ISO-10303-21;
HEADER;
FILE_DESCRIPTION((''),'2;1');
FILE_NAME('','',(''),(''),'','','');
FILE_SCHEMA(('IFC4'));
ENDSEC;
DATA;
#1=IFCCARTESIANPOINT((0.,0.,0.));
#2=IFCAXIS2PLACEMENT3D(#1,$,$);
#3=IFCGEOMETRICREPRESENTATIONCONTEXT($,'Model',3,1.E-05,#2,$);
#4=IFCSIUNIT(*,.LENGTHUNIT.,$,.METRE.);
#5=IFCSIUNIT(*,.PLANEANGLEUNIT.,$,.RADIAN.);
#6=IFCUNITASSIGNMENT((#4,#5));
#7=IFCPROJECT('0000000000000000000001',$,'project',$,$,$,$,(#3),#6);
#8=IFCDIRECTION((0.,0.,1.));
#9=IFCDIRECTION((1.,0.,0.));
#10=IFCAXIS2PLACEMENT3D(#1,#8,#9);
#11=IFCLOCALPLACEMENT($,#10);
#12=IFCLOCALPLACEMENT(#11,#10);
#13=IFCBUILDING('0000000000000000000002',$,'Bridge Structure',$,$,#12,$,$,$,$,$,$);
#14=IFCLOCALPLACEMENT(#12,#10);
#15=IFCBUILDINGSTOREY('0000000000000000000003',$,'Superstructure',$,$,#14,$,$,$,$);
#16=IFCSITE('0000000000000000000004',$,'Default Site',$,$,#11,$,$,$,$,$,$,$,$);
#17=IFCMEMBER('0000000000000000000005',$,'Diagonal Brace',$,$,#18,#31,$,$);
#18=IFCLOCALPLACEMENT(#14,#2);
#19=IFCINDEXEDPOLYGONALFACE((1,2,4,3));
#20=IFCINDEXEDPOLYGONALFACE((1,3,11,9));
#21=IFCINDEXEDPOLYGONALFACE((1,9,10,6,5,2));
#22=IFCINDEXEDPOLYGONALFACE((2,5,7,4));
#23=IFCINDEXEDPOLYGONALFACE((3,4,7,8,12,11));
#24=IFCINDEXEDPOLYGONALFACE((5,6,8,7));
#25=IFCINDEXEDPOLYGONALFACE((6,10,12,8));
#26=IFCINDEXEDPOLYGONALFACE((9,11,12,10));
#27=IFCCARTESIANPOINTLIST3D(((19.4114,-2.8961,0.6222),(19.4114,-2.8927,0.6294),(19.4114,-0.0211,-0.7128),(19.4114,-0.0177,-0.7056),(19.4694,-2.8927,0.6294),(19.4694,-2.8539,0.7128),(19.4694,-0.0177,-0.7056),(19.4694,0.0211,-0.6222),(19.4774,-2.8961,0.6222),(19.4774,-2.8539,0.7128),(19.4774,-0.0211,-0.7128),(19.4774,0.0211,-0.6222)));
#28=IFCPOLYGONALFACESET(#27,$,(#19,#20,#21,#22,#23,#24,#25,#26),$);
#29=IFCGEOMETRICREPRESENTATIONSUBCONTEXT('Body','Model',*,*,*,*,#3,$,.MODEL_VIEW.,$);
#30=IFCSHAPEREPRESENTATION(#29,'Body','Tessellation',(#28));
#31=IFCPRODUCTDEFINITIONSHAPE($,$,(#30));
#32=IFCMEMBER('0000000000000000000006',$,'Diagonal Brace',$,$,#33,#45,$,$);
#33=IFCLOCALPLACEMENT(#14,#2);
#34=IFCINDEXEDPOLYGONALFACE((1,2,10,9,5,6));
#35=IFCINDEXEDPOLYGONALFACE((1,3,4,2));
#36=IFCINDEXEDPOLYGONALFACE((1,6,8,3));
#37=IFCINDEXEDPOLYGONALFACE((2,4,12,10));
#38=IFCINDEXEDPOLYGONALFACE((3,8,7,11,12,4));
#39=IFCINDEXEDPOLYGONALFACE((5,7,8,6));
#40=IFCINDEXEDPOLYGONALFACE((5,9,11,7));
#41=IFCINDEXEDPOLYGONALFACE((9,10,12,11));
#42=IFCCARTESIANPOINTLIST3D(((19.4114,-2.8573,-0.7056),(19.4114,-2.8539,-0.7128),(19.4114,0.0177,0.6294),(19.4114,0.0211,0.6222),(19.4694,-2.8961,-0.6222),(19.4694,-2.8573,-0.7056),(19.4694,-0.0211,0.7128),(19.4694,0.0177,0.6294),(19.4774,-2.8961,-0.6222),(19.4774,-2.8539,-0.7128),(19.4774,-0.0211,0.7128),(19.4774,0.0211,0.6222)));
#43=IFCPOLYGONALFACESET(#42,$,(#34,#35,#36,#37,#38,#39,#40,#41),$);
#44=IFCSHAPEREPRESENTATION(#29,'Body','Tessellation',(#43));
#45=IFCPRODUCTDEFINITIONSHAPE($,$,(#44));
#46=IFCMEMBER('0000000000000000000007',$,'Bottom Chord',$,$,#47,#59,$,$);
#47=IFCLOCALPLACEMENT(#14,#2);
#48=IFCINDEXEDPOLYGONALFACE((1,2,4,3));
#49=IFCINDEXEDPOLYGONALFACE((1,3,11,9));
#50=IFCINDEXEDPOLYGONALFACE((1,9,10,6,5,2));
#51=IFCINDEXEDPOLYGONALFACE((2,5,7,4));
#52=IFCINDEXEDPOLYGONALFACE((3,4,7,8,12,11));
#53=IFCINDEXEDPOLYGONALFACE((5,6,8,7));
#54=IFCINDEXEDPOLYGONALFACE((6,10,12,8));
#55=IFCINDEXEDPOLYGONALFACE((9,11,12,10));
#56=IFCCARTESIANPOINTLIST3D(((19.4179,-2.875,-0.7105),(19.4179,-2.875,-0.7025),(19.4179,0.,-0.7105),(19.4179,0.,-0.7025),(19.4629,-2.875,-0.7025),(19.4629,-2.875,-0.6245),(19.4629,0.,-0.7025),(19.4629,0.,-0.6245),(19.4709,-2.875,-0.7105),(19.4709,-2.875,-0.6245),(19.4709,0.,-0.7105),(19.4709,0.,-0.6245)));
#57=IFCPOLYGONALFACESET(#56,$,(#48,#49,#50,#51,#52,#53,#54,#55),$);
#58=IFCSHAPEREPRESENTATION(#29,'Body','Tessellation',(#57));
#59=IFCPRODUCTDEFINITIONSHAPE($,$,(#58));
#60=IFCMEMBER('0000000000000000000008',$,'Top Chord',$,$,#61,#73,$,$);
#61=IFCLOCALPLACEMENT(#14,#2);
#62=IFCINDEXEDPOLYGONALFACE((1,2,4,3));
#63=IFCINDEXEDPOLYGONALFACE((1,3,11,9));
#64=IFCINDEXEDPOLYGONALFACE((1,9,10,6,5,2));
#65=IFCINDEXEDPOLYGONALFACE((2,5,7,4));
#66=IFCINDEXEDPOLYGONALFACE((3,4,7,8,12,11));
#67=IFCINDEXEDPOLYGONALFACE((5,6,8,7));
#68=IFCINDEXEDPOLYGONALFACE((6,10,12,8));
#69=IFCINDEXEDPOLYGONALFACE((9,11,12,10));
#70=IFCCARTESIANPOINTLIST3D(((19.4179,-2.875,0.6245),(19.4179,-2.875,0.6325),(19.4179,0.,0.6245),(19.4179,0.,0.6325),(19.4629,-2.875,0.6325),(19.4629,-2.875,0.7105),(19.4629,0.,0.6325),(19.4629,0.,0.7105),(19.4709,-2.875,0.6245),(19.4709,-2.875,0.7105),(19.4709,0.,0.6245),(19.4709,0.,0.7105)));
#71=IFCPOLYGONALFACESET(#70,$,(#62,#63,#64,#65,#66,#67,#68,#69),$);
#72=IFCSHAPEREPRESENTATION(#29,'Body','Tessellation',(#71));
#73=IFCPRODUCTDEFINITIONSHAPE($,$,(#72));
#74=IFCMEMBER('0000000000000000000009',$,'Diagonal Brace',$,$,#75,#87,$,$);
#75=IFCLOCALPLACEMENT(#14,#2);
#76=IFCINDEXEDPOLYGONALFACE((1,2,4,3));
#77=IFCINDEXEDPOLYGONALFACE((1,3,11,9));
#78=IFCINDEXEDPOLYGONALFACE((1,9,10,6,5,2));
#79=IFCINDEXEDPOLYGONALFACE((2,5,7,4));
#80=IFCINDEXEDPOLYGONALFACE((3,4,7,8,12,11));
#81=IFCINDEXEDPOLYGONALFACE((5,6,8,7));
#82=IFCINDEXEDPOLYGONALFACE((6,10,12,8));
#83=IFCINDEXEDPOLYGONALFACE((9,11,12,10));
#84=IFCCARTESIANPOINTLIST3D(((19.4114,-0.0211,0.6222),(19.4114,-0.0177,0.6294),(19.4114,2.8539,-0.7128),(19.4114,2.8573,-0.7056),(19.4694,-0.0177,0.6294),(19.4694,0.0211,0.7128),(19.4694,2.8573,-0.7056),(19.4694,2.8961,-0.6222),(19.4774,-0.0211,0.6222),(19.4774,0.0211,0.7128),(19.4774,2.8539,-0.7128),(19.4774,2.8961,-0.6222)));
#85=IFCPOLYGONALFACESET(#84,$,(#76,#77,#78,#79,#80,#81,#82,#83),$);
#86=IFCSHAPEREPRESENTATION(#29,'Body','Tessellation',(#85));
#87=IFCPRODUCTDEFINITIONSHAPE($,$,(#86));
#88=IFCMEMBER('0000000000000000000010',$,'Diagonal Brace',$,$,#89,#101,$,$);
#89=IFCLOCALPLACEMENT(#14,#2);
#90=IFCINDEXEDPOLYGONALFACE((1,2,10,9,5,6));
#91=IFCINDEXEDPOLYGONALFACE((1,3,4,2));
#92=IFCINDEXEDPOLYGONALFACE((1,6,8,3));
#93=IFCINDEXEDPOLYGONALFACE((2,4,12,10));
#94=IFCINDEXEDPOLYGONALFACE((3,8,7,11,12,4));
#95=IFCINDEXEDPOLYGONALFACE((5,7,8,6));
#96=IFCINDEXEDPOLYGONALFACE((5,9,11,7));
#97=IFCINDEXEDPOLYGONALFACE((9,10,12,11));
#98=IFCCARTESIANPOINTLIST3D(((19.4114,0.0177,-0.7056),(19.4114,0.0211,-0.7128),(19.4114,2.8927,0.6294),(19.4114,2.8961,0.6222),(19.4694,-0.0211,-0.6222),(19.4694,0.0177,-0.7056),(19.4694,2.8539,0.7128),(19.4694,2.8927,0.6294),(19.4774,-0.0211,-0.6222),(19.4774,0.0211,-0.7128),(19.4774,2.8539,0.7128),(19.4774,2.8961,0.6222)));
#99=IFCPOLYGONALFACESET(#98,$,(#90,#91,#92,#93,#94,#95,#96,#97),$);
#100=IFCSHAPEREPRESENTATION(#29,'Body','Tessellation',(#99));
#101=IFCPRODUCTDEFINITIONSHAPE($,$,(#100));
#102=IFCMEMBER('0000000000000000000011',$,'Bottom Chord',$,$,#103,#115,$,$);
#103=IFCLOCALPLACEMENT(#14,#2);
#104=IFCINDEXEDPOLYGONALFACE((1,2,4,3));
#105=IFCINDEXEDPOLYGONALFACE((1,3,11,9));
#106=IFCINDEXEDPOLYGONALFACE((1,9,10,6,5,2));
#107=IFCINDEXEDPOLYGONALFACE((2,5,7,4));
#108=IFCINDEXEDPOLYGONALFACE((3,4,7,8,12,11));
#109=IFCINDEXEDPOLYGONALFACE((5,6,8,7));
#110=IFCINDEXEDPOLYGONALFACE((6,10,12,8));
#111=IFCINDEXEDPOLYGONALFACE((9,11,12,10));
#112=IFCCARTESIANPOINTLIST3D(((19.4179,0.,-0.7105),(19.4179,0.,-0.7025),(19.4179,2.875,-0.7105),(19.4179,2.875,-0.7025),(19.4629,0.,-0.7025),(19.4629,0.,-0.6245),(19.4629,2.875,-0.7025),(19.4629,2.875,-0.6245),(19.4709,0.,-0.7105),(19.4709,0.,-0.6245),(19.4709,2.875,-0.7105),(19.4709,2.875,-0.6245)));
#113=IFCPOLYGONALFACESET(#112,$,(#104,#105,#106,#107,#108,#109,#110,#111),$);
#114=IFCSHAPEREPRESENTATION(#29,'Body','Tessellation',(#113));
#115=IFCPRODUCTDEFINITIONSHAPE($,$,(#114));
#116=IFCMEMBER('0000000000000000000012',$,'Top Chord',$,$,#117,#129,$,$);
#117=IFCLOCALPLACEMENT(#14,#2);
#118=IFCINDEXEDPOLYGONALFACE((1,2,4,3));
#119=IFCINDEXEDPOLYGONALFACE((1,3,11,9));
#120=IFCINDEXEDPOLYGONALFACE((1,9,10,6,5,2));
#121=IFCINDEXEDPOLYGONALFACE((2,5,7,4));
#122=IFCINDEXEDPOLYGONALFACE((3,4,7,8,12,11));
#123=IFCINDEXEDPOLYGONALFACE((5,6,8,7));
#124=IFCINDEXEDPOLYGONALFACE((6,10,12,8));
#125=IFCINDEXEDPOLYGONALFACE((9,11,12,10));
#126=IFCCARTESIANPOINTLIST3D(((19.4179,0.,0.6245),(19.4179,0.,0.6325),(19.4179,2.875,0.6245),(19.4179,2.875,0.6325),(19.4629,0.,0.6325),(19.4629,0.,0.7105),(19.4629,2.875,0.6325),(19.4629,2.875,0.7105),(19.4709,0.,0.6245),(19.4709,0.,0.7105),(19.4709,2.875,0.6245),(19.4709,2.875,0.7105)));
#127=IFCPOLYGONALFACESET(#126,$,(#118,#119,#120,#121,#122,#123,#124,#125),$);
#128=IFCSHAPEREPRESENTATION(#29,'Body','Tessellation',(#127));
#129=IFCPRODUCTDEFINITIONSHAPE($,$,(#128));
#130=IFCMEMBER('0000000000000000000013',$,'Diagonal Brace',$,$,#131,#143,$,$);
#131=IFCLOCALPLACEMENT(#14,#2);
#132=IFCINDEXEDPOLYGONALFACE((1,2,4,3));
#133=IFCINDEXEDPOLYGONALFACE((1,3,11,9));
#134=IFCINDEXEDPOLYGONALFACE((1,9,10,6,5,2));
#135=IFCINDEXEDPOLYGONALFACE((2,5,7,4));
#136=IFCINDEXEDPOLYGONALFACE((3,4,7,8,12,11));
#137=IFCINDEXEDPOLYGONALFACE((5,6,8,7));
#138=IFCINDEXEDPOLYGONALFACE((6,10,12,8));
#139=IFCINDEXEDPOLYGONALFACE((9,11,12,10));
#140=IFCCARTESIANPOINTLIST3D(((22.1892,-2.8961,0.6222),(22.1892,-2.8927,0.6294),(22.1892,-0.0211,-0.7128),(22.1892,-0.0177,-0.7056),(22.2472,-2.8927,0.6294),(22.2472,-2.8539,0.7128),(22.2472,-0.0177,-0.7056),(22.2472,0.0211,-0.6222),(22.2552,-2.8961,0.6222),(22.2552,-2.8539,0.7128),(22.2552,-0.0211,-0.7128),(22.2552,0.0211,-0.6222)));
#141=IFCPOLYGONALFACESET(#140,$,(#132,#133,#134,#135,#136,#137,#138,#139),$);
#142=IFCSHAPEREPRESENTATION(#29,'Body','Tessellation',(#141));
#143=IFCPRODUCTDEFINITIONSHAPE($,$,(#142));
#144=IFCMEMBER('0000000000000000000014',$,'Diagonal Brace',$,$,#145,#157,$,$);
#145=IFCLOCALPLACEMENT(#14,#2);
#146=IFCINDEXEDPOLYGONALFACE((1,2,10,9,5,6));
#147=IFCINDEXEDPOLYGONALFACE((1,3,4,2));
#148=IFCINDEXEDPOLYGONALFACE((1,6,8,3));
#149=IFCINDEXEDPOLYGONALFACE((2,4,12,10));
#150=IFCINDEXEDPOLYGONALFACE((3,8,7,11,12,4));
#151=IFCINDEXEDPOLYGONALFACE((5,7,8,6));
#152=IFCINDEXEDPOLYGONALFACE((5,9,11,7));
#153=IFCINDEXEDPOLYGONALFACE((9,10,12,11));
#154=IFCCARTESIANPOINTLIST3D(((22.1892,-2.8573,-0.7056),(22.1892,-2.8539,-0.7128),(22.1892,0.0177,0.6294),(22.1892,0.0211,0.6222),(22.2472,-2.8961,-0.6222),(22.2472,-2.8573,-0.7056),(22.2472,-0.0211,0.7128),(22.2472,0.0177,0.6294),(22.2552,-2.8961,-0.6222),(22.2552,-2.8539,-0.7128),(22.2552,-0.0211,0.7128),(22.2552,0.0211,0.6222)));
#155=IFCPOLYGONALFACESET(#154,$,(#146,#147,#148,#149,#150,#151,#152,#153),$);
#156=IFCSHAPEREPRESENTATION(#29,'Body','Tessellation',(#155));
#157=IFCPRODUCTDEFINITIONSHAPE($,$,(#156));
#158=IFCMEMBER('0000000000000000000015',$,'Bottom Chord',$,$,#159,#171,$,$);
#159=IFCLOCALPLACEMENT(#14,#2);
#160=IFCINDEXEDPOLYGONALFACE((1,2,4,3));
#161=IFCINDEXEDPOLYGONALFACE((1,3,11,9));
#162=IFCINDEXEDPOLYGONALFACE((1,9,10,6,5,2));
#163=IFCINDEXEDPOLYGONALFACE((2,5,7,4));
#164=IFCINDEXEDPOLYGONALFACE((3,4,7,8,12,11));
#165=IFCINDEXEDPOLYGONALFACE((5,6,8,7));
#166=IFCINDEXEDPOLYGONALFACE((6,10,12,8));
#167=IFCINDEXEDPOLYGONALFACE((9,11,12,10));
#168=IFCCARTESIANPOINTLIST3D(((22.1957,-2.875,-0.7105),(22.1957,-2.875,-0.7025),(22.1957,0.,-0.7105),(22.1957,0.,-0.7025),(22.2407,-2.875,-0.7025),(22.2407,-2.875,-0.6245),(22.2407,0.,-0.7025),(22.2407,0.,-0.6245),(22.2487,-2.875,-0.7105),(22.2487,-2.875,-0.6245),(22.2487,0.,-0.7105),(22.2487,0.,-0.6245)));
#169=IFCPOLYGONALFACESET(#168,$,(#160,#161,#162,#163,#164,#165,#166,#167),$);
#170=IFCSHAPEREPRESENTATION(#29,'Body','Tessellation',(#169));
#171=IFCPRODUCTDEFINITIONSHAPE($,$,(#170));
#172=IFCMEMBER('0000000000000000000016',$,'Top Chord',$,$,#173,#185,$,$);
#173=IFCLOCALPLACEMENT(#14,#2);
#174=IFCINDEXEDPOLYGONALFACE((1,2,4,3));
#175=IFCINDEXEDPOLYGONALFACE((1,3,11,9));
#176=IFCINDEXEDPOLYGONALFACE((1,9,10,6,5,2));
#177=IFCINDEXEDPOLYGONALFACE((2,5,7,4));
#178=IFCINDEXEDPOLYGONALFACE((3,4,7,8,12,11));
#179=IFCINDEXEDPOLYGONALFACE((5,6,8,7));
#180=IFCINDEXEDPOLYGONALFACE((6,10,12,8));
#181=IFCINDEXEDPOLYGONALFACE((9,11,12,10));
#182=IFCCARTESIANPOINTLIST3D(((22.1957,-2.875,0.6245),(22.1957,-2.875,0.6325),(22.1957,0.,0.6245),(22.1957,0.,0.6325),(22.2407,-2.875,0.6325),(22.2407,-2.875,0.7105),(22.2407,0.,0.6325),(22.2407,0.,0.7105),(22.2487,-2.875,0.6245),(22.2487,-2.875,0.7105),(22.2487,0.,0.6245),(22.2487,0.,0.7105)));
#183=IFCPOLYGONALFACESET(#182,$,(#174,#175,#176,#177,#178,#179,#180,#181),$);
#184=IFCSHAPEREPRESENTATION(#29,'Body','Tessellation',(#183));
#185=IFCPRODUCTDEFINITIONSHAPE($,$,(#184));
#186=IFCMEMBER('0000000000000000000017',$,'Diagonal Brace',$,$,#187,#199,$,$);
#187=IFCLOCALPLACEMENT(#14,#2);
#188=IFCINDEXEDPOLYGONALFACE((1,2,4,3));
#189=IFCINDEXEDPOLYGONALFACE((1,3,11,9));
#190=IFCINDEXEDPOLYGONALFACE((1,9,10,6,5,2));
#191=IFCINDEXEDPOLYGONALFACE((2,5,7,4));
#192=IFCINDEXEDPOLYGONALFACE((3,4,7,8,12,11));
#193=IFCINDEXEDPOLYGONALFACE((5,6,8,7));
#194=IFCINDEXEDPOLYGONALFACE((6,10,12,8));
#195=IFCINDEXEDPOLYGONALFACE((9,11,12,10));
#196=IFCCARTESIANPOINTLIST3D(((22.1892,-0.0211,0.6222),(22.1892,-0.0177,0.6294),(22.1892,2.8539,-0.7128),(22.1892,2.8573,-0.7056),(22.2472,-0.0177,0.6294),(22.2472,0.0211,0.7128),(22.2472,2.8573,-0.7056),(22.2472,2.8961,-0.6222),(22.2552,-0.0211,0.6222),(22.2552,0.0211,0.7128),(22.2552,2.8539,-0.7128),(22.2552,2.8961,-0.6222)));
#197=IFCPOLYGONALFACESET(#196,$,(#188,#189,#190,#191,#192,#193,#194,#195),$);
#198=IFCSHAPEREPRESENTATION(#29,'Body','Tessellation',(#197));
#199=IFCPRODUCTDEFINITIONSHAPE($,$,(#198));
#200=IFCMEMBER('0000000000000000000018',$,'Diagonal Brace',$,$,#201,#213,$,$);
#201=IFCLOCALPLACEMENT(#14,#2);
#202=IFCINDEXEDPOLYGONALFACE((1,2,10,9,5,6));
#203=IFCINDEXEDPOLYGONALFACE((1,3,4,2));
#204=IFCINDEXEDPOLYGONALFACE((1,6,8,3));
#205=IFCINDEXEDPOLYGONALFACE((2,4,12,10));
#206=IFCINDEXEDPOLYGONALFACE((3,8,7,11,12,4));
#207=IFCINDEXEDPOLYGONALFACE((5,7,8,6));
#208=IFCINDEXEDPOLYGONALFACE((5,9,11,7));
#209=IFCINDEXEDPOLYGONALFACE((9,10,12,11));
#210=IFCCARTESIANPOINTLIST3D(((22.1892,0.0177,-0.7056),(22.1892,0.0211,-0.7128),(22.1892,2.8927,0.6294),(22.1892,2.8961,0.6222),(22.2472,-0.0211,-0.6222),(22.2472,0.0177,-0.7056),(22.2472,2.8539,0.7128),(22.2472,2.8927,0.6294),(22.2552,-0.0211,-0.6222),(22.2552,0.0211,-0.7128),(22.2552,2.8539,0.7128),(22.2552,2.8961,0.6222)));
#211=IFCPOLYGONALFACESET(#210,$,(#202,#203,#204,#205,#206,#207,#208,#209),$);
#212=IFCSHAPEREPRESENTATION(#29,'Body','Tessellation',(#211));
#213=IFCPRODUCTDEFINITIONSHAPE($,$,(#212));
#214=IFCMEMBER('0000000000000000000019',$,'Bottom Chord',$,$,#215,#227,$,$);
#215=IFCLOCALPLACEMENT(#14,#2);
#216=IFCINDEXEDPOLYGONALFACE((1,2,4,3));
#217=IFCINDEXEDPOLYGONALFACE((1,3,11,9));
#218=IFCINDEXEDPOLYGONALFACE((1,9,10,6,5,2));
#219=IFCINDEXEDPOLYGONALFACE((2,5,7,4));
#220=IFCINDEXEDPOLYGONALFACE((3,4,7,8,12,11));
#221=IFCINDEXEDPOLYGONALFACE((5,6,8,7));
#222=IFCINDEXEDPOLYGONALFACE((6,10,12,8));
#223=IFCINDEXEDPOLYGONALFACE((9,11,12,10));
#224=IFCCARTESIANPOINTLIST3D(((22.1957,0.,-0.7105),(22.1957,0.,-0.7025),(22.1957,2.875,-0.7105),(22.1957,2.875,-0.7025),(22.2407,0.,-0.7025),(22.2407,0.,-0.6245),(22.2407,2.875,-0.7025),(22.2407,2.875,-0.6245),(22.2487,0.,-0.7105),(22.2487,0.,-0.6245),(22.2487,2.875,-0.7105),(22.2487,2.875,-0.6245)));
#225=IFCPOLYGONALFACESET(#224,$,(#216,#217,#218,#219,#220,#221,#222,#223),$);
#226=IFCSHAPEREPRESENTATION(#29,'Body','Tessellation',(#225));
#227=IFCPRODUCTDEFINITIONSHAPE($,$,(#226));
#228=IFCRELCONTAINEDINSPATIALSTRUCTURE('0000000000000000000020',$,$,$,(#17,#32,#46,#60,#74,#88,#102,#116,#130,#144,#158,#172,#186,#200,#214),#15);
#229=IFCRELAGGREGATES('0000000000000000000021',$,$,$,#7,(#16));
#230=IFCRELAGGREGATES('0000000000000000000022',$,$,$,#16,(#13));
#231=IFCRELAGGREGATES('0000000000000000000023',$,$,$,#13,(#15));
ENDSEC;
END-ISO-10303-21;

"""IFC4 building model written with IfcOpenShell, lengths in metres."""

from ifc_helpers import new_model, si_unit, frame, origin, origin_with_axes, origin_2d_with_axis, place, context, subcontext, project, spatial, l_section, extrude, element, save


model = new_model("IFC4")

# Units and contexts
model_context = context("Model", 3, precision=1e-05, world=origin())
body_context = subcontext(model_context, "Body", "Model", "MODEL_VIEW")
ifc_project = project(units=[si_unit("LENGTHUNIT", "METRE"), si_unit("PLANEANGLEUNIT", "RADIAN")], contexts=[model_context])

# Site, building, storey
site_placement = place(None, origin_with_axes())
site = spatial("IfcSite", under=ifc_project, at=site_placement, Name="Default Site")
building_placement = place(site_placement, origin_with_axes())
building = spatial("IfcBuilding", under=site, at=building_placement, Name="Bridge Structure")
storey_placement = place(building_placement, origin_with_axes())
storey = spatial("IfcBuildingStorey", under=building, at=storey_placement, Name="Superstructure")

# Members
for number, where, z_axis, x_axis, name in (
    (1, (19.4444, -2.875, 0.6675), (0.0, 0.906987, -0.421158), (-1.0, 0.0, 0.0), "Diagonal Brace"),
    (2, (19.4444, -2.875, -0.6675), (0.0, 0.906987, 0.421158), (-1.0, 0.0, 0.0), "Diagonal Brace"),
):
    element("IfcMember", number, at=place(storey_placement, frame(where, z_axis=z_axis, x_axis=x_axis)), inside=storey, Name=name, context=body_context, shape_type="SweptSolid", body=[
        extrude(l_section(Depth=0.1, Width=0.066, Thickness=0.008, at=origin_2d_with_axis()), origin_with_axes(), (0.0, 0.0, 1.0), 3.1698),
    ])
for number, where, z_axis, x_axis, name in (
    (3, (19.4444, -2.875, -0.6675), (0.0, 1.0, 0.0), (-1.0, 0.0, 0.0), "Bottom Chord"),
    (4, (19.4444, -2.875, 0.6675), (0.0, 1.0, 0.0), (-1.0, 0.0, 0.0), "Top Chord"),
):
    element("IfcMember", number, at=place(storey_placement, frame(where, z_axis=z_axis, x_axis=x_axis)), inside=storey, Name=name, context=body_context, shape_type="SweptSolid", body=[
        extrude(l_section(Depth=0.086, Width=0.053, Thickness=0.008, at=origin_2d_with_axis()), origin_with_axes(), (0.0, 0.0, 1.0), 2.875),
    ])
for number, where, z_axis, x_axis, name in (
    (5, (19.4444, 0.0, 0.6675), (0.0, 0.906987, -0.421158), (-1.0, 0.0, 0.0), "Diagonal Brace"),
    (6, (19.4444, 0.0, -0.6675), (0.0, 0.906987, 0.421158), (-1.0, 0.0, 0.0), "Diagonal Brace"),
):
    element("IfcMember", number, at=place(storey_placement, frame(where, z_axis=z_axis, x_axis=x_axis)), inside=storey, Name=name, context=body_context, shape_type="SweptSolid", body=[
        extrude(l_section(Depth=0.1, Width=0.066, Thickness=0.008, at=origin_2d_with_axis()), origin_with_axes(), (0.0, 0.0, 1.0), 3.1698),
    ])
for number, where, z_axis, x_axis, name in (
    (7, (19.4444, 0.0, -0.6675), (0.0, 1.0, 0.0), (-1.0, 0.0, 0.0), "Bottom Chord"),
    (8, (19.4444, 0.0, 0.6675), (0.0, 1.0, 0.0), (-1.0, 0.0, 0.0), "Top Chord"),
):
    element("IfcMember", number, at=place(storey_placement, frame(where, z_axis=z_axis, x_axis=x_axis)), inside=storey, Name=name, context=body_context, shape_type="SweptSolid", body=[
        extrude(l_section(Depth=0.086, Width=0.053, Thickness=0.008, at=origin_2d_with_axis()), origin_with_axes(), (0.0, 0.0, 1.0), 2.875),
    ])
for number, where, z_axis, x_axis, name in (
    (9, (22.2222, -2.875, 0.6675), (0.0, 0.906987, -0.421158), (-1.0, 0.0, 0.0), "Diagonal Brace"),
    (10, (22.2222, -2.875, -0.6675), (0.0, 0.906987, 0.421158), (-1.0, 0.0, 0.0), "Diagonal Brace"),
):
    element("IfcMember", number, at=place(storey_placement, frame(where, z_axis=z_axis, x_axis=x_axis)), inside=storey, Name=name, context=body_context, shape_type="SweptSolid", body=[
        extrude(l_section(Depth=0.1, Width=0.066, Thickness=0.008, at=origin_2d_with_axis()), origin_with_axes(), (0.0, 0.0, 1.0), 3.1698),
    ])
for number, where, z_axis, x_axis, name in (
    (11, (22.2222, -2.875, -0.6675), (0.0, 1.0, 0.0), (-1.0, 0.0, 0.0), "Bottom Chord"),
    (12, (22.2222, -2.875, 0.6675), (0.0, 1.0, 0.0), (-1.0, 0.0, 0.0), "Top Chord"),
):
    element("IfcMember", number, at=place(storey_placement, frame(where, z_axis=z_axis, x_axis=x_axis)), inside=storey, Name=name, context=body_context, shape_type="SweptSolid", body=[
        extrude(l_section(Depth=0.086, Width=0.053, Thickness=0.008, at=origin_2d_with_axis()), origin_with_axes(), (0.0, 0.0, 1.0), 2.875),
    ])
for number, where, z_axis, x_axis, name in (
    (13, (22.2222, 0.0, 0.6675), (0.0, 0.906987, -0.421158), (-1.0, 0.0, 0.0), "Diagonal Brace"),
    (14, (22.2222, 0.0, -0.6675), (0.0, 0.906987, 0.421158), (-1.0, 0.0, 0.0), "Diagonal Brace"),
):
    element("IfcMember", number, at=place(storey_placement, frame(where, z_axis=z_axis, x_axis=x_axis)), inside=storey, Name=name, context=body_context, shape_type="SweptSolid", body=[
        extrude(l_section(Depth=0.1, Width=0.066, Thickness=0.008, at=origin_2d_with_axis()), origin_with_axes(), (0.0, 0.0, 1.0), 3.1698),
    ])
for number, where, z_axis, x_axis, name in (
    (15, (22.2222, 0.0, -0.6675), (0.0, 1.0, 0.0), (-1.0, 0.0, 0.0), "Bottom Chord"),
):
    element("IfcMember", number, at=place(storey_placement, frame(where, z_axis=z_axis, x_axis=x_axis)), inside=storey, Name=name, context=body_context, shape_type="SweptSolid", body=[
        extrude(l_section(Depth=0.086, Width=0.053, Thickness=0.008, at=origin_2d_with_axis()), origin_with_axes(), (0.0, 0.0, 1.0), 2.875),
    ])

save(model, "model.ifc")
